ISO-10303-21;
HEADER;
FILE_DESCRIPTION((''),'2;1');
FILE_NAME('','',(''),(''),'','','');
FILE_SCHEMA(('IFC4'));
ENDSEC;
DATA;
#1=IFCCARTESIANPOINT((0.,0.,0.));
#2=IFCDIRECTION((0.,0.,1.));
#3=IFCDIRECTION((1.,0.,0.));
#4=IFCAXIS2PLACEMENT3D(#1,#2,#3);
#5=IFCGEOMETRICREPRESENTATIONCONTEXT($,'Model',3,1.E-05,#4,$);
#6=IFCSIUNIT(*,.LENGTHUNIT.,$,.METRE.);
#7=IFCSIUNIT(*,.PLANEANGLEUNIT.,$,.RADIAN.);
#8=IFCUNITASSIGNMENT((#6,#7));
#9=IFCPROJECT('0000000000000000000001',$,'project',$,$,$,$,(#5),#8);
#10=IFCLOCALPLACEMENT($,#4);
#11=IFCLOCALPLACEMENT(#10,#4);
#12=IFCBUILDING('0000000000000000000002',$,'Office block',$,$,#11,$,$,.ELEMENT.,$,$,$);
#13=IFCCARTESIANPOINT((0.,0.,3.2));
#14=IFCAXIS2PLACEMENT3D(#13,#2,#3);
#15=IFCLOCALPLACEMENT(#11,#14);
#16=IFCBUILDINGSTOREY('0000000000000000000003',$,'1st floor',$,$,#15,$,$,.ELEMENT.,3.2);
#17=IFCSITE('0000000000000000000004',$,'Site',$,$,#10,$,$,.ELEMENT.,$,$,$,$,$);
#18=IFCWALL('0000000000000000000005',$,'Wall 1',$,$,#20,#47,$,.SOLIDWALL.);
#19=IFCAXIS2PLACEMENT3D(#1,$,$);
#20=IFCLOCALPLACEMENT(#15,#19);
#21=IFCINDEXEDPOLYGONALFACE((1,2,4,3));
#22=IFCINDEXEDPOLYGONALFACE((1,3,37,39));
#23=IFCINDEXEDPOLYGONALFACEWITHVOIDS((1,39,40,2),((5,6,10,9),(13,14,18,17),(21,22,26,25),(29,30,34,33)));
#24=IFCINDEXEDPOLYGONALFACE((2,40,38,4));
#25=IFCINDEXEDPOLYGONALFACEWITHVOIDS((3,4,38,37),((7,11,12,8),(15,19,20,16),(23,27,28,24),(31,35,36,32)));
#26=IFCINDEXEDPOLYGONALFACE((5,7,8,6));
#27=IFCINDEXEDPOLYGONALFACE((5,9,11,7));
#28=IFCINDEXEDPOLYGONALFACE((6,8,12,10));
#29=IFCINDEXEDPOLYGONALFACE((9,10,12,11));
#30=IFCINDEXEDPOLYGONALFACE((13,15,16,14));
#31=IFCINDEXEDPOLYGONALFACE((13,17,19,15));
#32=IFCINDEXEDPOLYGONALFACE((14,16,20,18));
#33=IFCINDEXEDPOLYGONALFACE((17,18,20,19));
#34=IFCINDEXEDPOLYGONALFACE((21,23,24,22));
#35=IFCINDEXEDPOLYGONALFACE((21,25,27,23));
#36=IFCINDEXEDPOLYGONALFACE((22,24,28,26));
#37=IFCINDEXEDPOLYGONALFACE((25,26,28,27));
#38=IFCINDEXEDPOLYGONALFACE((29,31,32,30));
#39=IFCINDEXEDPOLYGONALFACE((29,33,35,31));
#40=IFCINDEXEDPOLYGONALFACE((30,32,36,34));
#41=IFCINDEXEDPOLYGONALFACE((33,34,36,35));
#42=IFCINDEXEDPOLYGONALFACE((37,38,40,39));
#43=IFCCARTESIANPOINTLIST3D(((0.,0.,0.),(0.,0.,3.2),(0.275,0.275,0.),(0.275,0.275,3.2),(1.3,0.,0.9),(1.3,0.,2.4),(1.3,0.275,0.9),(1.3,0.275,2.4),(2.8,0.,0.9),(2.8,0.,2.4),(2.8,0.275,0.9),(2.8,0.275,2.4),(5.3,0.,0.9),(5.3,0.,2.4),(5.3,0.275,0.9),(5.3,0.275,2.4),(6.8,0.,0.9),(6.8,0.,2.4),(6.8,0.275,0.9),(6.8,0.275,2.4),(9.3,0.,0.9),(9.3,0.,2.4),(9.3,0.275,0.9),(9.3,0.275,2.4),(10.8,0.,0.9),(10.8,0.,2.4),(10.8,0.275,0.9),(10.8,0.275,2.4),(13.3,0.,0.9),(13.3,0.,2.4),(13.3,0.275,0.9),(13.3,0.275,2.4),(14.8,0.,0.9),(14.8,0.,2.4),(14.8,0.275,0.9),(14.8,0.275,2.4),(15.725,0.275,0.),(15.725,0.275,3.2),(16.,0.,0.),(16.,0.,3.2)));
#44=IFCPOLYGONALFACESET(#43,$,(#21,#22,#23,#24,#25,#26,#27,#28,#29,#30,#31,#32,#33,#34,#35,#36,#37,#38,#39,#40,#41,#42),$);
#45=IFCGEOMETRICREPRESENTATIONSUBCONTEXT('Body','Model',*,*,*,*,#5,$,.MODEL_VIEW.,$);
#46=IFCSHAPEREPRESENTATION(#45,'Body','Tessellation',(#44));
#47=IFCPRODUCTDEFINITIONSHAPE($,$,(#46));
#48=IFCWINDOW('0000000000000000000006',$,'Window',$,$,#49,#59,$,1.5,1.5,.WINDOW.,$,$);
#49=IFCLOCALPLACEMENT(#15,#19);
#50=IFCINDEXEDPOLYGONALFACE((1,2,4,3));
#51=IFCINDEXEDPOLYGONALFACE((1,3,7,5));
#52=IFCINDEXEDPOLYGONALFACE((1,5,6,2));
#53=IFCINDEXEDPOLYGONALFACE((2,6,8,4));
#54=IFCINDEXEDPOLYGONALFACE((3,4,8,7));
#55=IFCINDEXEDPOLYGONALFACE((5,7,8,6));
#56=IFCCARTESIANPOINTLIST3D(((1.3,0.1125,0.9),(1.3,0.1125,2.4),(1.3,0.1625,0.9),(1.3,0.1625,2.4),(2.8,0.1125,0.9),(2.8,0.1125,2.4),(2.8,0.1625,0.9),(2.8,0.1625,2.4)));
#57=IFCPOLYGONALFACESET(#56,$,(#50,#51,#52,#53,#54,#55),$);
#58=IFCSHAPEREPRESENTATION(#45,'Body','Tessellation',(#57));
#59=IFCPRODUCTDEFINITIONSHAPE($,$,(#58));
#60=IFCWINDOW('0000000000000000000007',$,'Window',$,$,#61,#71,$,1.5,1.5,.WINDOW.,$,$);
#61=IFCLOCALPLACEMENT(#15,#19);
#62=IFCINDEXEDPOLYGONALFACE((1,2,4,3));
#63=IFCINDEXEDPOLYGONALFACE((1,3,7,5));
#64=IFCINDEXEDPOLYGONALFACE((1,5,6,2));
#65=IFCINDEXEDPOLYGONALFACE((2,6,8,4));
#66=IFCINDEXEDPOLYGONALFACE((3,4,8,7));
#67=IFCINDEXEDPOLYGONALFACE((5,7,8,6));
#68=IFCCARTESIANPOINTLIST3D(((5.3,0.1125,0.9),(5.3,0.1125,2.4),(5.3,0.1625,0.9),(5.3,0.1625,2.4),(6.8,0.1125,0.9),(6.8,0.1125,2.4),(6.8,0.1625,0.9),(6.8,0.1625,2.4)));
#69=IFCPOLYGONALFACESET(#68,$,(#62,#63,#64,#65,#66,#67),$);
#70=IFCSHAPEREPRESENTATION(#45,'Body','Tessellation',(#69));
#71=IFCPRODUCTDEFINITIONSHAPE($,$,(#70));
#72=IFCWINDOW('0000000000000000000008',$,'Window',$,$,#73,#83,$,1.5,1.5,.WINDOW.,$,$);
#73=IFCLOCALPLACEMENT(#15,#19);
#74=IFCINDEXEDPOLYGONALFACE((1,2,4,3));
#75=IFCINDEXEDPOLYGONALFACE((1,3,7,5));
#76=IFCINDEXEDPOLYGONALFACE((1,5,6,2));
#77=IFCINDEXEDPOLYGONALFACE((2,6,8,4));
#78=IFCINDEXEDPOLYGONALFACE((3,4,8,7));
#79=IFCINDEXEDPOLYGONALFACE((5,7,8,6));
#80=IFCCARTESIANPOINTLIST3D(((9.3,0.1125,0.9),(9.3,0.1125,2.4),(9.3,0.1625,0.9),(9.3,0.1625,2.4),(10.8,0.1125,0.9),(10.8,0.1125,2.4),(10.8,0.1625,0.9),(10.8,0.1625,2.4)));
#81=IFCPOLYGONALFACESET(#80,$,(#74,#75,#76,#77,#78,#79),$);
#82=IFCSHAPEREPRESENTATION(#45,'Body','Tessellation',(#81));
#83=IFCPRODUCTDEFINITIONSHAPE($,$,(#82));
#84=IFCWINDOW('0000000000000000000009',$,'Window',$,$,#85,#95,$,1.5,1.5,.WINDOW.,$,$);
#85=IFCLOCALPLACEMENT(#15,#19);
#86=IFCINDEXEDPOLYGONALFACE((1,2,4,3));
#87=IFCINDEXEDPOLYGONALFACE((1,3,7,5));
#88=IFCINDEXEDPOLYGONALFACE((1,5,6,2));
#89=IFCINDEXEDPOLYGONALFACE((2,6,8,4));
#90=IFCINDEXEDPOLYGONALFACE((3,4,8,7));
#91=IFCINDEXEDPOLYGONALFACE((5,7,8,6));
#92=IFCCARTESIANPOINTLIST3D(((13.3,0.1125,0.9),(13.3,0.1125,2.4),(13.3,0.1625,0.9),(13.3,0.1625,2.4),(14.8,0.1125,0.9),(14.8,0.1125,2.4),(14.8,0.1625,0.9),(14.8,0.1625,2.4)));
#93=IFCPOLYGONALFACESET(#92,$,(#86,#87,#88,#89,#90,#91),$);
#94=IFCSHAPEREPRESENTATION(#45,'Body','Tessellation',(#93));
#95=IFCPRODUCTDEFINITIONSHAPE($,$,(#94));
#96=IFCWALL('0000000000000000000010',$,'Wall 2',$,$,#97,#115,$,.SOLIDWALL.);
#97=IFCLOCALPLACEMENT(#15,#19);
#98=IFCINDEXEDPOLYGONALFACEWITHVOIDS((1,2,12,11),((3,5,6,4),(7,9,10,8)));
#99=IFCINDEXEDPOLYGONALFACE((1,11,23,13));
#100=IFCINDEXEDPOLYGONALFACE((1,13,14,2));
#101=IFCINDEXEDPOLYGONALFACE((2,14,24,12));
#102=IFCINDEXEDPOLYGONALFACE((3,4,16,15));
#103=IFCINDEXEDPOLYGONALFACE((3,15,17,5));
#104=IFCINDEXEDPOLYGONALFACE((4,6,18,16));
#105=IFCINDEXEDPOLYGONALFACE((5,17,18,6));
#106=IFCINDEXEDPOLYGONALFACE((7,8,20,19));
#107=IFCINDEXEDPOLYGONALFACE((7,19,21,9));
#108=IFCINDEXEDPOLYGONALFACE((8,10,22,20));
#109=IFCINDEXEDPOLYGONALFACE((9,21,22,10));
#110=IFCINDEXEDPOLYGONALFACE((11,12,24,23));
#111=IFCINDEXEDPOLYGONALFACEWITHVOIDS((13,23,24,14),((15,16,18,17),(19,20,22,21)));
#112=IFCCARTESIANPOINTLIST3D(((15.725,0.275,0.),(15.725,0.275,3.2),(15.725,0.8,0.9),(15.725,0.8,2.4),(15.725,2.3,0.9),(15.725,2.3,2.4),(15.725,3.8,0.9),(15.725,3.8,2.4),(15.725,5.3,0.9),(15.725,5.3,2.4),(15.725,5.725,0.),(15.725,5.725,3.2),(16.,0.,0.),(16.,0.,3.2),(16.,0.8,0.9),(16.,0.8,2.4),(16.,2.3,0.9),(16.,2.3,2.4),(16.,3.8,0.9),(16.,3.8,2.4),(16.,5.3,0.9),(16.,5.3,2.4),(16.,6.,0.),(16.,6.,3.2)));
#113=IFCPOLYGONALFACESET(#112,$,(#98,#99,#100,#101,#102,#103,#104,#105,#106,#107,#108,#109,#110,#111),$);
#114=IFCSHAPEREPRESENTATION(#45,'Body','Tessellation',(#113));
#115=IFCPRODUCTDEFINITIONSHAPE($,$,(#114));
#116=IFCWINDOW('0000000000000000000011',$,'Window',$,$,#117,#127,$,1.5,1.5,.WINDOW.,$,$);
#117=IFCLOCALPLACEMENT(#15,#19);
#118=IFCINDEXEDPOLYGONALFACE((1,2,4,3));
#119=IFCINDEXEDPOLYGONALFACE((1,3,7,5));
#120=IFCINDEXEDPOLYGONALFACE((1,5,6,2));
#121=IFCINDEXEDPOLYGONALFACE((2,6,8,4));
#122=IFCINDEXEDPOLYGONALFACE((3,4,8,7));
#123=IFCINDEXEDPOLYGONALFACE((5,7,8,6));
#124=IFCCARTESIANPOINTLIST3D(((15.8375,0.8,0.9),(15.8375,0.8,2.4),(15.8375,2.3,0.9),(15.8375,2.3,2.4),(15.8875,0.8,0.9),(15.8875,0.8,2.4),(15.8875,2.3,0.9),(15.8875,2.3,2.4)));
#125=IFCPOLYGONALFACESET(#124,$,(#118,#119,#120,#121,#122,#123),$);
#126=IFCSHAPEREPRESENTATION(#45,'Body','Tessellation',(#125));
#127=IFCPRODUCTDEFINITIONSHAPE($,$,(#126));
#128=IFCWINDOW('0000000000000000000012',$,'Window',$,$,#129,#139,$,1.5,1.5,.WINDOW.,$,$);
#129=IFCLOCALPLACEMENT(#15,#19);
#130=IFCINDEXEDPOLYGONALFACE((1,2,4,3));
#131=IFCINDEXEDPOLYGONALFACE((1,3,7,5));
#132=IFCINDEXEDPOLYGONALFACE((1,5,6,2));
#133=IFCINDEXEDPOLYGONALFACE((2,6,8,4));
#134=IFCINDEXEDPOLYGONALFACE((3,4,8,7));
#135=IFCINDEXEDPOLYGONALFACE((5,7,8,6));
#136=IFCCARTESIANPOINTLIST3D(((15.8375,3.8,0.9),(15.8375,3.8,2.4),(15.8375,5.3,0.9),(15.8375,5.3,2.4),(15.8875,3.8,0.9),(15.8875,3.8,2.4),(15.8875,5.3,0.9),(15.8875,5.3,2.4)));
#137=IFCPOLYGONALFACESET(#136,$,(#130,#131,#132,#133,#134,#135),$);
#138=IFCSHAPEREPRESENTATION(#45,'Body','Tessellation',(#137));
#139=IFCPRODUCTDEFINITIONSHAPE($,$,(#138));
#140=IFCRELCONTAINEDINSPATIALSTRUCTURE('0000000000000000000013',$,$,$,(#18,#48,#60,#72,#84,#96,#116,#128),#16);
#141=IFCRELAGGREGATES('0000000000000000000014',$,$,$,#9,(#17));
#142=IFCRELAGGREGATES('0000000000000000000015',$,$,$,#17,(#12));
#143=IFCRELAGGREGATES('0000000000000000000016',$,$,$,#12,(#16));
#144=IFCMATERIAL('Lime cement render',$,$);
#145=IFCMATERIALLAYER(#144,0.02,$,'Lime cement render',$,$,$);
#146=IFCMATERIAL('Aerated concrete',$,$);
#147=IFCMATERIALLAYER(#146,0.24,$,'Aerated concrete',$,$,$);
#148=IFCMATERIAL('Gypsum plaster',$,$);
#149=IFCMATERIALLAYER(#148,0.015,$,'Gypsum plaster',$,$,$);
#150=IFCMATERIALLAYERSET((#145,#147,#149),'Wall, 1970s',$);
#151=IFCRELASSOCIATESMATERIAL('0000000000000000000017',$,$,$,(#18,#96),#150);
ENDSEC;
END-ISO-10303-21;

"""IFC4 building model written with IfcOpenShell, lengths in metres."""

from ifc_helpers import new_model, si_unit, frame, origin_with_axes, place, context, subcontext, project, spatial, polyline, outline, extrude, material, layer, layer_set, layer_usage, element, fill, save


model = new_model("IFC4")

# Units and contexts
model_context = context("Model", 3, precision=1e-05, world=origin_with_axes())
body_context = subcontext(model_context, "Body", "Model", "MODEL_VIEW")
ifc_project = project(units=[si_unit("LENGTHUNIT", "METRE"), si_unit("PLANEANGLEUNIT", "RADIAN")], contexts=[model_context])

# Site, building, storey
site_placement = place(None, origin_with_axes())
site = spatial("IfcSite", under=ifc_project, at=site_placement, Name="Site", CompositionType="ELEMENT")
building_placement = place(site_placement, origin_with_axes())
building = spatial("IfcBuilding", under=site, at=building_placement, Name="Office block", CompositionType="ELEMENT")
storey_placement = place(building_placement, frame((0.0, 0.0, 3.2), z_axis=(0.0, 0.0, 1.0), x_axis=(1.0, 0.0, 0.0)))
storey = spatial("IfcBuildingStorey", under=building, at=storey_placement, Name="1st floor", CompositionType="ELEMENT", Elevation=3.2)

# Walls, openings, windows
ifc_material_1 = material(Name="Lime cement render")
ifc_layer_1 = layer(ifc_material_1, 0.02, Name="Lime cement render")
ifc_material_2 = material(Name="Aerated concrete")
ifc_layer_2 = layer(ifc_material_2, 0.24, Name="Aerated concrete")
ifc_material_3 = material(Name="Gypsum plaster")
ifc_layer_3 = layer(ifc_material_3, 0.015, Name="Gypsum plaster")
ifc_layer_set = layer_set([ifc_layer_1, ifc_layer_2, ifc_layer_3], Name="Wall, 1970s")
ifc_layer_usage_1 = layer_usage(ifc_layer_set, "AXIS2", "NEGATIVE", 0.0)
wall_1_placement = place(storey_placement, origin_with_axes())
wall_1 = element("IfcWall", 1, at=wall_1_placement, inside=storey, material=ifc_layer_usage_1, Name="Wall 1", PredefinedType="SOLIDWALL", context=body_context, shape_type="SweptSolid", body=[
    extrude(outline(polyline([(0.0, 0.0), (16.0, 0.0), (15.725, 0.275), (0.275, 0.275), (0.0, 0.0)])), origin_with_axes(), (0.0, 0.0, 1.0), 3.2),
])
opening_1_placement = place(storey_placement, origin_with_axes())
opening_1 = element("IfcOpeningElement", 2, at=opening_1_placement, cuts=wall_1, PredefinedType="OPENING", context=body_context, shape_type="SweptSolid", body=[
    extrude(outline(polyline([(1.3, -0.01), (2.8, -0.01), (2.8, 0.285), (1.3, 0.285), (1.3, -0.01)])), frame((0.0, 0.0, 0.9), z_axis=(0.0, 0.0, 1.0), x_axis=(1.0, 0.0, 0.0)), (0.0, 0.0, 1.0), 1.5),
])
opening_2_placement = place(storey_placement, origin_with_axes())
opening_2 = element("IfcOpeningElement", 3, at=opening_2_placement, cuts=wall_1, PredefinedType="OPENING", context=body_context, shape_type="SweptSolid", body=[
    extrude(outline(polyline([(5.3, -0.01), (6.8, -0.01), (6.8, 0.285), (5.3, 0.285), (5.3, -0.01)])), frame((0.0, 0.0, 0.9), z_axis=(0.0, 0.0, 1.0), x_axis=(1.0, 0.0, 0.0)), (0.0, 0.0, 1.0), 1.5),
])
opening_3_placement = place(storey_placement, origin_with_axes())
opening_3 = element("IfcOpeningElement", 4, at=opening_3_placement, cuts=wall_1, PredefinedType="OPENING", context=body_context, shape_type="SweptSolid", body=[
    extrude(outline(polyline([(9.3, -0.01), (10.8, -0.01), (10.8, 0.285), (9.3, 0.285), (9.3, -0.01)])), frame((0.0, 0.0, 0.9), z_axis=(0.0, 0.0, 1.0), x_axis=(1.0, 0.0, 0.0)), (0.0, 0.0, 1.0), 1.5),
])
opening_4_placement = place(storey_placement, origin_with_axes())
opening_4 = element("IfcOpeningElement", 5, at=opening_4_placement, cuts=wall_1, PredefinedType="OPENING", context=body_context, shape_type="SweptSolid", body=[
    extrude(outline(polyline([(13.3, -0.01), (14.8, -0.01), (14.8, 0.285), (13.3, 0.285), (13.3, -0.01)])), frame((0.0, 0.0, 0.9), z_axis=(0.0, 0.0, 1.0), x_axis=(1.0, 0.0, 0.0)), (0.0, 0.0, 1.0), 1.5),
])
window_1_placement = place(storey_placement, origin_with_axes())
window_1 = element("IfcWindow", 6, at=window_1_placement, inside=storey, Name="Window", OverallHeight=1.5, OverallWidth=1.5, PredefinedType="WINDOW", context=body_context, shape_type="SweptSolid", body=[
    extrude(outline(polyline([(1.3, 0.1125), (2.8, 0.1125), (2.8, 0.1625), (1.3, 0.1625), (1.3, 0.1125)])), frame((0.0, 0.0, 0.9), z_axis=(0.0, 0.0, 1.0), x_axis=(1.0, 0.0, 0.0)), (0.0, 0.0, 1.0), 1.5),
])
fill(opening_1, window_1)
window_2_placement = place(storey_placement, origin_with_axes())
window_2 = element("IfcWindow", 7, at=window_2_placement, inside=storey, Name="Window", OverallHeight=1.5, OverallWidth=1.5, PredefinedType="WINDOW", context=body_context, shape_type="SweptSolid", body=[
    extrude(outline(polyline([(5.3, 0.1125), (6.8, 0.1125), (6.8, 0.1625), (5.3, 0.1625), (5.3, 0.1125)])), frame((0.0, 0.0, 0.9), z_axis=(0.0, 0.0, 1.0), x_axis=(1.0, 0.0, 0.0)), (0.0, 0.0, 1.0), 1.5),
])
fill(opening_2, window_2)
window_3_placement = place(storey_placement, origin_with_axes())
window_3 = element("IfcWindow", 8, at=window_3_placement, inside=storey, Name="Window", OverallHeight=1.5, OverallWidth=1.5, PredefinedType="WINDOW", context=body_context, shape_type="SweptSolid", body=[
    extrude(outline(polyline([(9.3, 0.1125), (10.8, 0.1125), (10.8, 0.1625), (9.3, 0.1625), (9.3, 0.1125)])), frame((0.0, 0.0, 0.9), z_axis=(0.0, 0.0, 1.0), x_axis=(1.0, 0.0, 0.0)), (0.0, 0.0, 1.0), 1.5),
])
fill(opening_3, window_3)
window_4_placement = place(storey_placement, origin_with_axes())
window_4 = element("IfcWindow", 9, at=window_4_placement, inside=storey, Name="Window", OverallHeight=1.5, OverallWidth=1.5, PredefinedType="WINDOW", context=body_context, shape_type="SweptSolid", body=[
    extrude(outline(polyline([(13.3, 0.1125), (14.8, 0.1125), (14.8, 0.1625), (13.3, 0.1625), (13.3, 0.1125)])), frame((0.0, 0.0, 0.9), z_axis=(0.0, 0.0, 1.0), x_axis=(1.0, 0.0, 0.0)), (0.0, 0.0, 1.0), 1.5),
])
fill(opening_4, window_4)
ifc_layer_usage_2 = layer_usage(ifc_layer_set, "AXIS2", "NEGATIVE", 0.0)
wall_2_placement = place(storey_placement, origin_with_axes())
wall_2 = element("IfcWall", 10, at=wall_2_placement, inside=storey, material=ifc_layer_usage_2, Name="Wall 2", PredefinedType="SOLIDWALL", context=body_context, shape_type="SweptSolid", body=[
    extrude(outline(polyline([(16.0, 0.0), (16.0, 6.0), (15.725, 5.725), (15.725, 0.275), (16.0, 0.0)])), origin_with_axes(), (0.0, 0.0, 1.0), 3.2),
])
opening_5_placement = place(storey_placement, origin_with_axes())
opening_5 = element("IfcOpeningElement", 11, at=opening_5_placement, cuts=wall_2, PredefinedType="OPENING", context=body_context, shape_type="SweptSolid", body=[
    extrude(outline(polyline([(16.01, 0.8), (16.01, 2.3), (15.715, 2.3), (15.715, 0.8), (16.01, 0.8)])), frame((0.0, 0.0, 0.9), z_axis=(0.0, 0.0, 1.0), x_axis=(1.0, 0.0, 0.0)), (0.0, 0.0, 1.0), 1.5),
])
opening_6_placement = place(storey_placement, origin_with_axes())
opening_6 = element("IfcOpeningElement", 12, at=opening_6_placement, cuts=wall_2, PredefinedType="OPENING", context=body_context, shape_type="SweptSolid", body=[
    extrude(outline(polyline([(16.01, 3.8), (16.01, 5.3), (15.715, 5.3), (15.715, 3.8), (16.01, 3.8)])), frame((0.0, 0.0, 0.9), z_axis=(0.0, 0.0, 1.0), x_axis=(1.0, 0.0, 0.0)), (0.0, 0.0, 1.0), 1.5),
])
window_5_placement = place(storey_placement, origin_with_axes())
window_5 = element("IfcWindow", 13, at=window_5_placement, inside=storey, Name="Window", OverallHeight=1.5, OverallWidth=1.5, PredefinedType="WINDOW", context=body_context, shape_type="SweptSolid", body=[
    extrude(outline(polyline([(15.8875, 0.8), (15.8875, 2.3), (15.8375, 2.3), (15.8375, 0.8), (15.8875, 0.8)])), frame((0.0, 0.0, 0.9), z_axis=(0.0, 0.0, 1.0), x_axis=(1.0, 0.0, 0.0)), (0.0, 0.0, 1.0), 1.5),
])
fill(opening_5, window_5)
window_6_placement = place(storey_placement, origin_with_axes())
window_6 = element("IfcWindow", 14, at=window_6_placement, inside=storey, Name="Window", OverallHeight=1.5, OverallWidth=1.5, PredefinedType="WINDOW", context=body_context, shape_type="SweptSolid", body=[
    extrude(outline(polyline([(15.8875, 3.8), (15.8875, 5.3), (15.8375, 5.3), (15.8375, 3.8), (15.8875, 3.8)])), frame((0.0, 0.0, 0.9), z_axis=(0.0, 0.0, 1.0), x_axis=(1.0, 0.0, 0.0)), (0.0, 0.0, 1.0), 1.5),
])
fill(opening_6, window_6)

save(model, "model.ifc")
